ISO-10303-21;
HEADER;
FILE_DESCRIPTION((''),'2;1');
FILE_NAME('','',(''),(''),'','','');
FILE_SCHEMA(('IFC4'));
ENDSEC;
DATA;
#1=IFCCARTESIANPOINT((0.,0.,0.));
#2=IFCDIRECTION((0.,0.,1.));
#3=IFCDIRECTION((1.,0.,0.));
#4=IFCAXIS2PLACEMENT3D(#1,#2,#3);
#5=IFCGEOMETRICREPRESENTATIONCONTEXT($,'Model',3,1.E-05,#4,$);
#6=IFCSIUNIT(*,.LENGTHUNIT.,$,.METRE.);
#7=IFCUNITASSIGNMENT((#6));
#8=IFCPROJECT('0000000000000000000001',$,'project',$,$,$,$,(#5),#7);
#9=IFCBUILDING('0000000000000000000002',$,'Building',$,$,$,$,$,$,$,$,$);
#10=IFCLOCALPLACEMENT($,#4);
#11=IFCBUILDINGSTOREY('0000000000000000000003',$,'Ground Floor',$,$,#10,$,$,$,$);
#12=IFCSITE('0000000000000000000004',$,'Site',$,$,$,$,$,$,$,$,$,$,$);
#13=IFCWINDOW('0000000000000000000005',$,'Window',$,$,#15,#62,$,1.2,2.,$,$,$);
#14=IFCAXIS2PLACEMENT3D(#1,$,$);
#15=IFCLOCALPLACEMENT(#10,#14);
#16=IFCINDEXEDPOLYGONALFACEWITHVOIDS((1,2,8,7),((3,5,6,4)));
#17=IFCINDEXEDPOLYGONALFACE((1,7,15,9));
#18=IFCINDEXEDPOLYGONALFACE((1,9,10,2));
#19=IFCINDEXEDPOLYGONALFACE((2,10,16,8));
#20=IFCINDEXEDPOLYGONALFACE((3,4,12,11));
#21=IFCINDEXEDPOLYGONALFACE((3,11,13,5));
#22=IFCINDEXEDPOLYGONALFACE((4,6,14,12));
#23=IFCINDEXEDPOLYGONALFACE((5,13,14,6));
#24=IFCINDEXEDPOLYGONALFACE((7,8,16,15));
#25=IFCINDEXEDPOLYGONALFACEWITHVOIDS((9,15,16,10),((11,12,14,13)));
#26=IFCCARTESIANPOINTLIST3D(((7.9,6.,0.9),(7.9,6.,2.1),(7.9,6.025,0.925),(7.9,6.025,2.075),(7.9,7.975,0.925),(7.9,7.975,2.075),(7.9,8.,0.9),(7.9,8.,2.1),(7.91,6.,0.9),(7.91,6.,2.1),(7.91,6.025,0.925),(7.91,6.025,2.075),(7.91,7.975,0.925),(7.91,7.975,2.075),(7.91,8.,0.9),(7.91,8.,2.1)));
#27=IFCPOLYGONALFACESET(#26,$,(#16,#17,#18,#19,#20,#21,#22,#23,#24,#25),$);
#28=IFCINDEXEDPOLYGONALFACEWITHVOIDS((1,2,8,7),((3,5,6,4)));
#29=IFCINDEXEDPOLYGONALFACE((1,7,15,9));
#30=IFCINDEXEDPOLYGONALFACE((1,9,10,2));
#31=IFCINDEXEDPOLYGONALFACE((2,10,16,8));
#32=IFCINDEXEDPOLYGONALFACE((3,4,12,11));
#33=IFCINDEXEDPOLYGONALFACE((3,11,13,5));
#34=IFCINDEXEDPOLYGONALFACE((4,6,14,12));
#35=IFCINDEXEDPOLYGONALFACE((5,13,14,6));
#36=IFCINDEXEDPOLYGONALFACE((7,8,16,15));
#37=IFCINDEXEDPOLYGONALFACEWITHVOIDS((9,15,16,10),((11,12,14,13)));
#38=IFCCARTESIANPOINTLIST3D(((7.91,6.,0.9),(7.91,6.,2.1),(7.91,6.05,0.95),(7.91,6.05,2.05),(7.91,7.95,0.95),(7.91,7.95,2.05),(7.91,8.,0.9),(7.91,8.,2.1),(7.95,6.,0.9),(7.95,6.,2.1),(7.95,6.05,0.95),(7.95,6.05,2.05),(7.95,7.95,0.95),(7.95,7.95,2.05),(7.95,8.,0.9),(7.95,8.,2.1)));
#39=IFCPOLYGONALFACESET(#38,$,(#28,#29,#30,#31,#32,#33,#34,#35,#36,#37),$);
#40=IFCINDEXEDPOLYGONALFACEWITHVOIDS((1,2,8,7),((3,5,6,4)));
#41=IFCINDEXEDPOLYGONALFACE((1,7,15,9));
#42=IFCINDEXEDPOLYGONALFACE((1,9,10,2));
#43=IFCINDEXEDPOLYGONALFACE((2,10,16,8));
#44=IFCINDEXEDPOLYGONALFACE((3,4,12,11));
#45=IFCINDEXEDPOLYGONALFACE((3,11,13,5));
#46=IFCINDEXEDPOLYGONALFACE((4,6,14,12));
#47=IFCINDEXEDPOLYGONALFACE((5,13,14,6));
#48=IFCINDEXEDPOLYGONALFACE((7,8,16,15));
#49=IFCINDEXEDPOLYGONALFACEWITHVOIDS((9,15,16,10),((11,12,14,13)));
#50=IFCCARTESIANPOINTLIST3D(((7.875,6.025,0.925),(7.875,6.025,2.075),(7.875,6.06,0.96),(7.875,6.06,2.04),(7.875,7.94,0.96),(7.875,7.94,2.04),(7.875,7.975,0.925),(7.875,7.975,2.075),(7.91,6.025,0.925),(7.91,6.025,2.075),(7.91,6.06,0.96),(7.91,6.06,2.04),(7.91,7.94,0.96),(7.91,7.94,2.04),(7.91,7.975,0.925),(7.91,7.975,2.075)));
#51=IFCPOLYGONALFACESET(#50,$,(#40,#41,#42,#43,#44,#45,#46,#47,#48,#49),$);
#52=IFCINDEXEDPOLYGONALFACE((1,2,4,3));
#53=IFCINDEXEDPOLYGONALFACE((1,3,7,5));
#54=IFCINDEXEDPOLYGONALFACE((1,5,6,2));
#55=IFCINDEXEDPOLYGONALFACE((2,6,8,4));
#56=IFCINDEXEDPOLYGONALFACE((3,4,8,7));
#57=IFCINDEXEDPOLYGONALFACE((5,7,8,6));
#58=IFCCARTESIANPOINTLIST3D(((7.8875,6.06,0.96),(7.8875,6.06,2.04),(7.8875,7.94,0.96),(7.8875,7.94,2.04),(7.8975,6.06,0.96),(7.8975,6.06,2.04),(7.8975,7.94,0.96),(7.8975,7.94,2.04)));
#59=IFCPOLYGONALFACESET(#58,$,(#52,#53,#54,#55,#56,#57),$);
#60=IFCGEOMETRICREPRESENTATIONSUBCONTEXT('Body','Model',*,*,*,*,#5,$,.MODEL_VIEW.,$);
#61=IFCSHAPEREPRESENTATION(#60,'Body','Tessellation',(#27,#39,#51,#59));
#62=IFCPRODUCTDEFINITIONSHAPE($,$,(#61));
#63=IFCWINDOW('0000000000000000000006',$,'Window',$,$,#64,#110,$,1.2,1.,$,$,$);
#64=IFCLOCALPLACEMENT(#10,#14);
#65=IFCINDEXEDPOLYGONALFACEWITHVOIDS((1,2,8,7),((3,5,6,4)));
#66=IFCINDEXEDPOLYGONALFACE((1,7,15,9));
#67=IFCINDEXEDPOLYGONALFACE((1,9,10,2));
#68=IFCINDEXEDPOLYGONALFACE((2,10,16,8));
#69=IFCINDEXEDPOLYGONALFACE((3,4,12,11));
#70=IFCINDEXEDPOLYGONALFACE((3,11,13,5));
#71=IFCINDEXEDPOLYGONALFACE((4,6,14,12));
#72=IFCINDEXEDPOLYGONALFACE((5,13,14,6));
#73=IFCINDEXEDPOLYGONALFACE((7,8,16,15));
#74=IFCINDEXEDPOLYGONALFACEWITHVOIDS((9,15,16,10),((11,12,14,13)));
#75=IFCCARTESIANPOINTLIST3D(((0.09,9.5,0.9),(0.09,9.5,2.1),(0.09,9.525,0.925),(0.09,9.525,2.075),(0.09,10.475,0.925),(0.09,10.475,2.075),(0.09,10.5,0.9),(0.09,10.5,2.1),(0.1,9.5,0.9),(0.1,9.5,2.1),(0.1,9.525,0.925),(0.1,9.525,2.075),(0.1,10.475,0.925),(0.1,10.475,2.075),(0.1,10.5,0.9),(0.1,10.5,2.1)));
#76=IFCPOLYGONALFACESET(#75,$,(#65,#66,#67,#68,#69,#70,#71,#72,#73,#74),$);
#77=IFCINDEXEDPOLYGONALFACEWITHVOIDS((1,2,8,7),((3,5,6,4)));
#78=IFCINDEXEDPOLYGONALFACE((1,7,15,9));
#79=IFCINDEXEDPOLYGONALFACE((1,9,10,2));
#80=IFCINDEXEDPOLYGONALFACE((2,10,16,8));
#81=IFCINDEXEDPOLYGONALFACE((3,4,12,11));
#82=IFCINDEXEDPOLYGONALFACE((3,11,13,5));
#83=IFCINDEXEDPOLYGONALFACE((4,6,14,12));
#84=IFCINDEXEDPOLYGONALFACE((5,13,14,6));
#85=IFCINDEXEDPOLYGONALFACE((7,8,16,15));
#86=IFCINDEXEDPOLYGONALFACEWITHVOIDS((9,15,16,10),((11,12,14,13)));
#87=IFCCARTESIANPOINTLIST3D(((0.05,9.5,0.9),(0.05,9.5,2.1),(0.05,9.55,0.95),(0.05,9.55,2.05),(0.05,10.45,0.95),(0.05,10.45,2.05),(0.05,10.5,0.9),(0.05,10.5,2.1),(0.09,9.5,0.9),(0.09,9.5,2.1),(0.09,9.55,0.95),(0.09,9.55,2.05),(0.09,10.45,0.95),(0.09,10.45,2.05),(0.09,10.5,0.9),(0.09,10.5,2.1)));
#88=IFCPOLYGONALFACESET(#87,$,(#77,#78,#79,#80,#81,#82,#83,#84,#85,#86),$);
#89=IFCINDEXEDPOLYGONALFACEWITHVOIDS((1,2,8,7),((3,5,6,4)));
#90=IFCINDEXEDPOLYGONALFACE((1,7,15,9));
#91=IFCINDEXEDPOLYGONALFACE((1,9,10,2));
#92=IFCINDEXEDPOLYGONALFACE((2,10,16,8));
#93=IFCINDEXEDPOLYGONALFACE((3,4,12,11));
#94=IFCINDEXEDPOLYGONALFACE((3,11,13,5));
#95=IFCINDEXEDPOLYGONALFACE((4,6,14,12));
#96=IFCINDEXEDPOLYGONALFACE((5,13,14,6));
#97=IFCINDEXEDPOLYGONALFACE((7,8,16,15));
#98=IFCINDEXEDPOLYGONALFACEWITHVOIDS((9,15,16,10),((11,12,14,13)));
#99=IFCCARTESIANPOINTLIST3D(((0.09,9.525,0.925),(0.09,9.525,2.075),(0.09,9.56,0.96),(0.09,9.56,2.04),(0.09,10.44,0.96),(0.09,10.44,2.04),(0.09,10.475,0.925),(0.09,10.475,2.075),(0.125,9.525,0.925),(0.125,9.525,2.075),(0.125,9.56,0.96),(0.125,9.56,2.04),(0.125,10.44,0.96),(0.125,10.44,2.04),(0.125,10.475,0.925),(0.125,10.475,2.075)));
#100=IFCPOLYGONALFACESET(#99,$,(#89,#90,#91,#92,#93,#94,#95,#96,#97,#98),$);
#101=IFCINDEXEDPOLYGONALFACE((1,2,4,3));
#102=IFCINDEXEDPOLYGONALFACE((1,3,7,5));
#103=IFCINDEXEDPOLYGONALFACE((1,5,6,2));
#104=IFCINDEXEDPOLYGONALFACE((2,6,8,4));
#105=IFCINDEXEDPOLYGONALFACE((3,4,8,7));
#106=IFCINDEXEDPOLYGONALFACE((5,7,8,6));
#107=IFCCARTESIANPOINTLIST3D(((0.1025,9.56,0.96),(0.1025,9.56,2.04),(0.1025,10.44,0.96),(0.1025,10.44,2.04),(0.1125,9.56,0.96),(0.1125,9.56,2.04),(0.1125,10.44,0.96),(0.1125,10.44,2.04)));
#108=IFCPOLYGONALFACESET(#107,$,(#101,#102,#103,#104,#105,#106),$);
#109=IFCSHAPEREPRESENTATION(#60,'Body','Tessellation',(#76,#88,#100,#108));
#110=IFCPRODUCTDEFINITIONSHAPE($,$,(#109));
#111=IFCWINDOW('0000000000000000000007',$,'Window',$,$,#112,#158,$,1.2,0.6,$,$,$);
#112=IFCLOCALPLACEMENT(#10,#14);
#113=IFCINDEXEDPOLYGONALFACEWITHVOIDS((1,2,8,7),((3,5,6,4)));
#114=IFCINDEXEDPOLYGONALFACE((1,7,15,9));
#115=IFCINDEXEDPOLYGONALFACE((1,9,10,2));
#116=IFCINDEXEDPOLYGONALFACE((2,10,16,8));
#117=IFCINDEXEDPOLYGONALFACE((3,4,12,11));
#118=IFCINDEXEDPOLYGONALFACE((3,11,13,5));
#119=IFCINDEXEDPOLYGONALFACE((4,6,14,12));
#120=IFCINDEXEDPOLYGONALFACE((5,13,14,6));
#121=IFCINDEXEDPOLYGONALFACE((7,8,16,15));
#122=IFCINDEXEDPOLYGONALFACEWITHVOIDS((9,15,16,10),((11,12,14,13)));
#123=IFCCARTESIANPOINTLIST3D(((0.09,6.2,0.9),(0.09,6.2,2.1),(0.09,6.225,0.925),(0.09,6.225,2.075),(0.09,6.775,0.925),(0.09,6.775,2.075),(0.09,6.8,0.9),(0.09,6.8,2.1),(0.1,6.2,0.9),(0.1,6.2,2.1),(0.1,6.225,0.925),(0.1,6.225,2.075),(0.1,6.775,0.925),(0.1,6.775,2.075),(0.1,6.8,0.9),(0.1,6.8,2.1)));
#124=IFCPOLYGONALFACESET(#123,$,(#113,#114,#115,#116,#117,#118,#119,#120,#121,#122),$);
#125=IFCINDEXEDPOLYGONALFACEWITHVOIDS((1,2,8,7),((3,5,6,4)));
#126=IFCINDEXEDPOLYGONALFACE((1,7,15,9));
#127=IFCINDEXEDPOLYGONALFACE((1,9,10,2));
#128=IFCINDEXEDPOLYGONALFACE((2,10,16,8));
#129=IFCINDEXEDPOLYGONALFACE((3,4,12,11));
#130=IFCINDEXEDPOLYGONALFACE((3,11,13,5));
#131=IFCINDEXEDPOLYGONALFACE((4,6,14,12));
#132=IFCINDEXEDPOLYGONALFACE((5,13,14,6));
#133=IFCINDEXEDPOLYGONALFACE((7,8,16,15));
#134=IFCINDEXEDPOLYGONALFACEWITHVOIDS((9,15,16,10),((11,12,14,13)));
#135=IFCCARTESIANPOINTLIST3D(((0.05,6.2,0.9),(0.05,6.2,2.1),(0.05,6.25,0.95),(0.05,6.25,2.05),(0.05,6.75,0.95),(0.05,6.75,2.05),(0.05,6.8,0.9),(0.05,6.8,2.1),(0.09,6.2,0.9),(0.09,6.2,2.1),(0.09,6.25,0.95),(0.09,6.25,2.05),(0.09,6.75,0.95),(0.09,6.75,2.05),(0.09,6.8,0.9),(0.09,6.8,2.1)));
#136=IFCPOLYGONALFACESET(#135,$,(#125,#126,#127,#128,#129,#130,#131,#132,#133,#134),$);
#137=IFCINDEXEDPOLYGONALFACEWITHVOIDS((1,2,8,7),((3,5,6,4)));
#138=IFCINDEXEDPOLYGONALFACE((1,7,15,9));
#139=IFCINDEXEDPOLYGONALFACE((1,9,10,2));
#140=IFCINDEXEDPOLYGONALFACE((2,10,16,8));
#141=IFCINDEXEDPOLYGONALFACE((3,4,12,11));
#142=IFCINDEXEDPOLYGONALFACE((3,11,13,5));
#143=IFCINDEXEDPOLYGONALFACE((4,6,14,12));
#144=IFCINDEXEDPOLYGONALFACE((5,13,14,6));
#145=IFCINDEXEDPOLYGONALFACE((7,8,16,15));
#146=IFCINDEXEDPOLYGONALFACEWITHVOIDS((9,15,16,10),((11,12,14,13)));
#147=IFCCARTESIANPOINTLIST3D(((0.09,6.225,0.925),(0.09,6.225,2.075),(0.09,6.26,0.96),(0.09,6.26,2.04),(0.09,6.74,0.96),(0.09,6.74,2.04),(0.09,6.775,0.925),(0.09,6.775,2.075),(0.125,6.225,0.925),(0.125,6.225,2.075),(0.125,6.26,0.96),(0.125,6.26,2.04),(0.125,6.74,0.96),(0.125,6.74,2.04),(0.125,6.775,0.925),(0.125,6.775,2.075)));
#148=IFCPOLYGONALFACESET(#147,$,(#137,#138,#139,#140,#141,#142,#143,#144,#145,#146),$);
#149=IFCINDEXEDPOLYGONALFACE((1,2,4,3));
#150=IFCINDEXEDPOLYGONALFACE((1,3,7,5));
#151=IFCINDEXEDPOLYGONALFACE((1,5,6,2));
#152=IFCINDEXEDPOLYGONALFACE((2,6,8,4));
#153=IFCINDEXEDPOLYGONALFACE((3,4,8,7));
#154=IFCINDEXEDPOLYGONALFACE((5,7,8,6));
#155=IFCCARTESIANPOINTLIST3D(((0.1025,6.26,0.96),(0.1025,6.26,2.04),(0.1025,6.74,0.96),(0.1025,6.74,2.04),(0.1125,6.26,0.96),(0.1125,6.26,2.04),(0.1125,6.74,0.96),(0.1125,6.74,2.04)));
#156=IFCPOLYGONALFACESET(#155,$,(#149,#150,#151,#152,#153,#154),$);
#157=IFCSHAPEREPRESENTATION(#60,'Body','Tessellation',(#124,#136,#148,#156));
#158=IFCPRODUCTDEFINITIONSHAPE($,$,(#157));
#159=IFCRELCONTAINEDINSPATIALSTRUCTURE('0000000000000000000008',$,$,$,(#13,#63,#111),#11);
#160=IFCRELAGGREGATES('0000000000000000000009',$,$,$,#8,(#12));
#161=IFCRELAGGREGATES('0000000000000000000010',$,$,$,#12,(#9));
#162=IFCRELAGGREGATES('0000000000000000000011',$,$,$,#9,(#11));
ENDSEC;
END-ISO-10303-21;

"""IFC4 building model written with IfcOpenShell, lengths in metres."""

from ifc_helpers import new_model, si_unit, frame, origin_with_axes, place, context, subcontext, project, spatial, line, indexed_curve, outline, extrude, element, save


model = new_model("IFC4")

# Units and contexts
model_context = context("Model", 3, precision=1e-05, world=origin_with_axes())
body_context = subcontext(model_context, "Body", "Model", "MODEL_VIEW")
ifc_project = project(units=[si_unit("LENGTHUNIT", "METRE")], contexts=[model_context])

# Site, building, storey
site = spatial("IfcSite", under=ifc_project, Name="Site")
building = spatial("IfcBuilding", under=site, Name="Building")
storey_placement = place(None, origin_with_axes())
storey = spatial("IfcBuildingStorey", under=building, at=storey_placement, Name="Ground Floor")

# Windows
window_1_placement = place(storey_placement, frame((8.0, 6.0, 0.9), z_axis=(0.0, 0.0, 1.0), x_axis=(0.0, 1.0, 0.0)))
element("IfcWindow", 1, at=window_1_placement, inside=storey, Name="Window", OverallHeight=1.2, OverallWidth=2.0, context=body_context, shape_type="SweptSolid", body=[
    extrude(outline(indexed_curve([(0.0, 0.0), (2.0, 0.0), (2.0, 1.2), (0.0, 1.2)], segments=[line(1, 2, 3, 4, 1)]), holes=[indexed_curve([(0.025, 0.025), (1.975, 0.025), (1.975, 1.175), (0.025, 1.175)], segments=[line(1, 2, 3, 4, 1)])]), frame((0.0, 0.09, 0.0), z_axis=(0.0, -1.0, 0.0), x_axis=(1.0, 0.0, 0.0)), (0.0, 0.0, -1.0), 0.01),
    extrude(outline(indexed_curve([(0.0, 0.0), (2.0, 0.0), (2.0, 1.2), (0.0, 1.2)], segments=[line(1, 2, 3, 4, 1)]), holes=[indexed_curve([(0.05, 0.05), (1.95, 0.05), (1.95, 1.15), (0.05, 1.15)], segments=[line(1, 2, 3, 4, 1)])]), frame((0.0, 0.05, 0.0), z_axis=(0.0, -1.0, 0.0), x_axis=(1.0, 0.0, 0.0)), (0.0, 0.0, -1.0), 0.04),
    extrude(outline(indexed_curve([(0.0, 0.0), (1.95, 0.0), (1.95, 1.15), (0.0, 1.15)], segments=[line(1, 2, 3, 4, 1)]), holes=[indexed_curve([(0.035, 0.035), (1.915, 0.035), (1.915, 1.115), (0.035, 1.115)], segments=[line(1, 2, 3, 4, 1)])]), frame((0.025, 0.09, 0.025), z_axis=(0.0, -1.0, 0.0), x_axis=(1.0, 0.0, 0.0)), (0.0, 0.0, -1.0), 0.035),
    extrude(outline(indexed_curve([(0.035, 0.035), (1.915, 0.035), (1.915, 1.115), (0.035, 1.115)], segments=[line(1, 2, 3, 4, 1)])), frame((0.025, 0.1025, 0.025), z_axis=(0.0, -1.0, 0.0), x_axis=(1.0, 0.0, 0.0)), (0.0, 0.0, -1.0), 0.01),
])
window_2_placement = place(storey_placement, frame((0.0, 10.5, 0.9), z_axis=(0.0, 0.0, 1.0), x_axis=(0.0, -1.0, 0.0)))
element("IfcWindow", 2, at=window_2_placement, inside=storey, Name="Window", OverallHeight=1.2, OverallWidth=1.0, context=body_context, shape_type="SweptSolid", body=[
    extrude(outline(indexed_curve([(0.0, 0.0), (1.0, 0.0), (1.0, 1.2), (0.0, 1.2)], segments=[line(1, 2, 3, 4, 1)]), holes=[indexed_curve([(0.025, 0.025), (0.975, 0.025), (0.975, 1.175), (0.025, 1.175)], segments=[line(1, 2, 3, 4, 1)])]), frame((0.0, 0.09, 0.0), z_axis=(0.0, -1.0, 0.0), x_axis=(1.0, 0.0, 0.0)), (0.0, 0.0, -1.0), 0.01),
    extrude(outline(indexed_curve([(0.0, 0.0), (1.0, 0.0), (1.0, 1.2), (0.0, 1.2)], segments=[line(1, 2, 3, 4, 1)]), holes=[indexed_curve([(0.05, 0.05), (0.95, 0.05), (0.95, 1.15), (0.05, 1.15)], segments=[line(1, 2, 3, 4, 1)])]), frame((0.0, 0.05, 0.0), z_axis=(0.0, -1.0, 0.0), x_axis=(1.0, 0.0, 0.0)), (0.0, 0.0, -1.0), 0.04),
    extrude(outline(indexed_curve([(0.0, 0.0), (0.95, 0.0), (0.95, 1.15), (0.0, 1.15)], segments=[line(1, 2, 3, 4, 1)]), holes=[indexed_curve([(0.035, 0.035), (0.915, 0.035), (0.915, 1.115), (0.035, 1.115)], segments=[line(1, 2, 3, 4, 1)])]), frame((0.025, 0.09, 0.025), z_axis=(0.0, -1.0, 0.0), x_axis=(1.0, 0.0, 0.0)), (0.0, 0.0, -1.0), 0.035),
    extrude(outline(indexed_curve([(0.035, 0.035), (0.915, 0.035), (0.915, 1.115), (0.035, 1.115)], segments=[line(1, 2, 3, 4, 1)])), frame((0.025, 0.1025, 0.025), z_axis=(0.0, -1.0, 0.0), x_axis=(1.0, 0.0, 0.0)), (0.0, 0.0, -1.0), 0.01),
])
window_3_placement = place(storey_placement, frame((0.0, 6.8, 0.9), z_axis=(0.0, 0.0, 1.0), x_axis=(0.0, -1.0, 0.0)))
element("IfcWindow", 3, at=window_3_placement, inside=storey, Name="Window", OverallHeight=1.2, OverallWidth=0.6, context=body_context, shape_type="SweptSolid", body=[
    extrude(outline(indexed_curve([(0.0, 0.0), (0.6, 0.0), (0.6, 1.2), (0.0, 1.2)], segments=[line(1, 2, 3, 4, 1)]), holes=[indexed_curve([(0.025, 0.025), (0.575, 0.025), (0.575, 1.175), (0.025, 1.175)], segments=[line(1, 2, 3, 4, 1)])]), frame((0.0, 0.09, 0.0), z_axis=(0.0, -1.0, 0.0), x_axis=(1.0, 0.0, 0.0)), (0.0, 0.0, -1.0), 0.01),
    extrude(outline(indexed_curve([(0.0, 0.0), (0.6, 0.0), (0.6, 1.2), (0.0, 1.2)], segments=[line(1, 2, 3, 4, 1)]), holes=[indexed_curve([(0.05, 0.05), (0.55, 0.05), (0.55, 1.15), (0.05, 1.15)], segments=[line(1, 2, 3, 4, 1)])]), frame((0.0, 0.05, 0.0), z_axis=(0.0, -1.0, 0.0), x_axis=(1.0, 0.0, 0.0)), (0.0, 0.0, -1.0), 0.04),
    extrude(outline(indexed_curve([(0.0, 0.0), (0.55, 0.0), (0.55, 1.15), (0.0, 1.15)], segments=[line(1, 2, 3, 4, 1)]), holes=[indexed_curve([(0.035, 0.035), (0.515, 0.035), (0.515, 1.115), (0.035, 1.115)], segments=[line(1, 2, 3, 4, 1)])]), frame((0.025, 0.09, 0.025), z_axis=(0.0, -1.0, 0.0), x_axis=(1.0, 0.0, 0.0)), (0.0, 0.0, -1.0), 0.035),
    extrude(outline(indexed_curve([(0.035, 0.035), (0.515, 0.035), (0.515, 1.115), (0.035, 1.115)], segments=[line(1, 2, 3, 4, 1)])), frame((0.025, 0.1025, 0.025), z_axis=(0.0, -1.0, 0.0), x_axis=(1.0, 0.0, 0.0)), (0.0, 0.0, -1.0), 0.01),
])

save(model, "model.ifc")
